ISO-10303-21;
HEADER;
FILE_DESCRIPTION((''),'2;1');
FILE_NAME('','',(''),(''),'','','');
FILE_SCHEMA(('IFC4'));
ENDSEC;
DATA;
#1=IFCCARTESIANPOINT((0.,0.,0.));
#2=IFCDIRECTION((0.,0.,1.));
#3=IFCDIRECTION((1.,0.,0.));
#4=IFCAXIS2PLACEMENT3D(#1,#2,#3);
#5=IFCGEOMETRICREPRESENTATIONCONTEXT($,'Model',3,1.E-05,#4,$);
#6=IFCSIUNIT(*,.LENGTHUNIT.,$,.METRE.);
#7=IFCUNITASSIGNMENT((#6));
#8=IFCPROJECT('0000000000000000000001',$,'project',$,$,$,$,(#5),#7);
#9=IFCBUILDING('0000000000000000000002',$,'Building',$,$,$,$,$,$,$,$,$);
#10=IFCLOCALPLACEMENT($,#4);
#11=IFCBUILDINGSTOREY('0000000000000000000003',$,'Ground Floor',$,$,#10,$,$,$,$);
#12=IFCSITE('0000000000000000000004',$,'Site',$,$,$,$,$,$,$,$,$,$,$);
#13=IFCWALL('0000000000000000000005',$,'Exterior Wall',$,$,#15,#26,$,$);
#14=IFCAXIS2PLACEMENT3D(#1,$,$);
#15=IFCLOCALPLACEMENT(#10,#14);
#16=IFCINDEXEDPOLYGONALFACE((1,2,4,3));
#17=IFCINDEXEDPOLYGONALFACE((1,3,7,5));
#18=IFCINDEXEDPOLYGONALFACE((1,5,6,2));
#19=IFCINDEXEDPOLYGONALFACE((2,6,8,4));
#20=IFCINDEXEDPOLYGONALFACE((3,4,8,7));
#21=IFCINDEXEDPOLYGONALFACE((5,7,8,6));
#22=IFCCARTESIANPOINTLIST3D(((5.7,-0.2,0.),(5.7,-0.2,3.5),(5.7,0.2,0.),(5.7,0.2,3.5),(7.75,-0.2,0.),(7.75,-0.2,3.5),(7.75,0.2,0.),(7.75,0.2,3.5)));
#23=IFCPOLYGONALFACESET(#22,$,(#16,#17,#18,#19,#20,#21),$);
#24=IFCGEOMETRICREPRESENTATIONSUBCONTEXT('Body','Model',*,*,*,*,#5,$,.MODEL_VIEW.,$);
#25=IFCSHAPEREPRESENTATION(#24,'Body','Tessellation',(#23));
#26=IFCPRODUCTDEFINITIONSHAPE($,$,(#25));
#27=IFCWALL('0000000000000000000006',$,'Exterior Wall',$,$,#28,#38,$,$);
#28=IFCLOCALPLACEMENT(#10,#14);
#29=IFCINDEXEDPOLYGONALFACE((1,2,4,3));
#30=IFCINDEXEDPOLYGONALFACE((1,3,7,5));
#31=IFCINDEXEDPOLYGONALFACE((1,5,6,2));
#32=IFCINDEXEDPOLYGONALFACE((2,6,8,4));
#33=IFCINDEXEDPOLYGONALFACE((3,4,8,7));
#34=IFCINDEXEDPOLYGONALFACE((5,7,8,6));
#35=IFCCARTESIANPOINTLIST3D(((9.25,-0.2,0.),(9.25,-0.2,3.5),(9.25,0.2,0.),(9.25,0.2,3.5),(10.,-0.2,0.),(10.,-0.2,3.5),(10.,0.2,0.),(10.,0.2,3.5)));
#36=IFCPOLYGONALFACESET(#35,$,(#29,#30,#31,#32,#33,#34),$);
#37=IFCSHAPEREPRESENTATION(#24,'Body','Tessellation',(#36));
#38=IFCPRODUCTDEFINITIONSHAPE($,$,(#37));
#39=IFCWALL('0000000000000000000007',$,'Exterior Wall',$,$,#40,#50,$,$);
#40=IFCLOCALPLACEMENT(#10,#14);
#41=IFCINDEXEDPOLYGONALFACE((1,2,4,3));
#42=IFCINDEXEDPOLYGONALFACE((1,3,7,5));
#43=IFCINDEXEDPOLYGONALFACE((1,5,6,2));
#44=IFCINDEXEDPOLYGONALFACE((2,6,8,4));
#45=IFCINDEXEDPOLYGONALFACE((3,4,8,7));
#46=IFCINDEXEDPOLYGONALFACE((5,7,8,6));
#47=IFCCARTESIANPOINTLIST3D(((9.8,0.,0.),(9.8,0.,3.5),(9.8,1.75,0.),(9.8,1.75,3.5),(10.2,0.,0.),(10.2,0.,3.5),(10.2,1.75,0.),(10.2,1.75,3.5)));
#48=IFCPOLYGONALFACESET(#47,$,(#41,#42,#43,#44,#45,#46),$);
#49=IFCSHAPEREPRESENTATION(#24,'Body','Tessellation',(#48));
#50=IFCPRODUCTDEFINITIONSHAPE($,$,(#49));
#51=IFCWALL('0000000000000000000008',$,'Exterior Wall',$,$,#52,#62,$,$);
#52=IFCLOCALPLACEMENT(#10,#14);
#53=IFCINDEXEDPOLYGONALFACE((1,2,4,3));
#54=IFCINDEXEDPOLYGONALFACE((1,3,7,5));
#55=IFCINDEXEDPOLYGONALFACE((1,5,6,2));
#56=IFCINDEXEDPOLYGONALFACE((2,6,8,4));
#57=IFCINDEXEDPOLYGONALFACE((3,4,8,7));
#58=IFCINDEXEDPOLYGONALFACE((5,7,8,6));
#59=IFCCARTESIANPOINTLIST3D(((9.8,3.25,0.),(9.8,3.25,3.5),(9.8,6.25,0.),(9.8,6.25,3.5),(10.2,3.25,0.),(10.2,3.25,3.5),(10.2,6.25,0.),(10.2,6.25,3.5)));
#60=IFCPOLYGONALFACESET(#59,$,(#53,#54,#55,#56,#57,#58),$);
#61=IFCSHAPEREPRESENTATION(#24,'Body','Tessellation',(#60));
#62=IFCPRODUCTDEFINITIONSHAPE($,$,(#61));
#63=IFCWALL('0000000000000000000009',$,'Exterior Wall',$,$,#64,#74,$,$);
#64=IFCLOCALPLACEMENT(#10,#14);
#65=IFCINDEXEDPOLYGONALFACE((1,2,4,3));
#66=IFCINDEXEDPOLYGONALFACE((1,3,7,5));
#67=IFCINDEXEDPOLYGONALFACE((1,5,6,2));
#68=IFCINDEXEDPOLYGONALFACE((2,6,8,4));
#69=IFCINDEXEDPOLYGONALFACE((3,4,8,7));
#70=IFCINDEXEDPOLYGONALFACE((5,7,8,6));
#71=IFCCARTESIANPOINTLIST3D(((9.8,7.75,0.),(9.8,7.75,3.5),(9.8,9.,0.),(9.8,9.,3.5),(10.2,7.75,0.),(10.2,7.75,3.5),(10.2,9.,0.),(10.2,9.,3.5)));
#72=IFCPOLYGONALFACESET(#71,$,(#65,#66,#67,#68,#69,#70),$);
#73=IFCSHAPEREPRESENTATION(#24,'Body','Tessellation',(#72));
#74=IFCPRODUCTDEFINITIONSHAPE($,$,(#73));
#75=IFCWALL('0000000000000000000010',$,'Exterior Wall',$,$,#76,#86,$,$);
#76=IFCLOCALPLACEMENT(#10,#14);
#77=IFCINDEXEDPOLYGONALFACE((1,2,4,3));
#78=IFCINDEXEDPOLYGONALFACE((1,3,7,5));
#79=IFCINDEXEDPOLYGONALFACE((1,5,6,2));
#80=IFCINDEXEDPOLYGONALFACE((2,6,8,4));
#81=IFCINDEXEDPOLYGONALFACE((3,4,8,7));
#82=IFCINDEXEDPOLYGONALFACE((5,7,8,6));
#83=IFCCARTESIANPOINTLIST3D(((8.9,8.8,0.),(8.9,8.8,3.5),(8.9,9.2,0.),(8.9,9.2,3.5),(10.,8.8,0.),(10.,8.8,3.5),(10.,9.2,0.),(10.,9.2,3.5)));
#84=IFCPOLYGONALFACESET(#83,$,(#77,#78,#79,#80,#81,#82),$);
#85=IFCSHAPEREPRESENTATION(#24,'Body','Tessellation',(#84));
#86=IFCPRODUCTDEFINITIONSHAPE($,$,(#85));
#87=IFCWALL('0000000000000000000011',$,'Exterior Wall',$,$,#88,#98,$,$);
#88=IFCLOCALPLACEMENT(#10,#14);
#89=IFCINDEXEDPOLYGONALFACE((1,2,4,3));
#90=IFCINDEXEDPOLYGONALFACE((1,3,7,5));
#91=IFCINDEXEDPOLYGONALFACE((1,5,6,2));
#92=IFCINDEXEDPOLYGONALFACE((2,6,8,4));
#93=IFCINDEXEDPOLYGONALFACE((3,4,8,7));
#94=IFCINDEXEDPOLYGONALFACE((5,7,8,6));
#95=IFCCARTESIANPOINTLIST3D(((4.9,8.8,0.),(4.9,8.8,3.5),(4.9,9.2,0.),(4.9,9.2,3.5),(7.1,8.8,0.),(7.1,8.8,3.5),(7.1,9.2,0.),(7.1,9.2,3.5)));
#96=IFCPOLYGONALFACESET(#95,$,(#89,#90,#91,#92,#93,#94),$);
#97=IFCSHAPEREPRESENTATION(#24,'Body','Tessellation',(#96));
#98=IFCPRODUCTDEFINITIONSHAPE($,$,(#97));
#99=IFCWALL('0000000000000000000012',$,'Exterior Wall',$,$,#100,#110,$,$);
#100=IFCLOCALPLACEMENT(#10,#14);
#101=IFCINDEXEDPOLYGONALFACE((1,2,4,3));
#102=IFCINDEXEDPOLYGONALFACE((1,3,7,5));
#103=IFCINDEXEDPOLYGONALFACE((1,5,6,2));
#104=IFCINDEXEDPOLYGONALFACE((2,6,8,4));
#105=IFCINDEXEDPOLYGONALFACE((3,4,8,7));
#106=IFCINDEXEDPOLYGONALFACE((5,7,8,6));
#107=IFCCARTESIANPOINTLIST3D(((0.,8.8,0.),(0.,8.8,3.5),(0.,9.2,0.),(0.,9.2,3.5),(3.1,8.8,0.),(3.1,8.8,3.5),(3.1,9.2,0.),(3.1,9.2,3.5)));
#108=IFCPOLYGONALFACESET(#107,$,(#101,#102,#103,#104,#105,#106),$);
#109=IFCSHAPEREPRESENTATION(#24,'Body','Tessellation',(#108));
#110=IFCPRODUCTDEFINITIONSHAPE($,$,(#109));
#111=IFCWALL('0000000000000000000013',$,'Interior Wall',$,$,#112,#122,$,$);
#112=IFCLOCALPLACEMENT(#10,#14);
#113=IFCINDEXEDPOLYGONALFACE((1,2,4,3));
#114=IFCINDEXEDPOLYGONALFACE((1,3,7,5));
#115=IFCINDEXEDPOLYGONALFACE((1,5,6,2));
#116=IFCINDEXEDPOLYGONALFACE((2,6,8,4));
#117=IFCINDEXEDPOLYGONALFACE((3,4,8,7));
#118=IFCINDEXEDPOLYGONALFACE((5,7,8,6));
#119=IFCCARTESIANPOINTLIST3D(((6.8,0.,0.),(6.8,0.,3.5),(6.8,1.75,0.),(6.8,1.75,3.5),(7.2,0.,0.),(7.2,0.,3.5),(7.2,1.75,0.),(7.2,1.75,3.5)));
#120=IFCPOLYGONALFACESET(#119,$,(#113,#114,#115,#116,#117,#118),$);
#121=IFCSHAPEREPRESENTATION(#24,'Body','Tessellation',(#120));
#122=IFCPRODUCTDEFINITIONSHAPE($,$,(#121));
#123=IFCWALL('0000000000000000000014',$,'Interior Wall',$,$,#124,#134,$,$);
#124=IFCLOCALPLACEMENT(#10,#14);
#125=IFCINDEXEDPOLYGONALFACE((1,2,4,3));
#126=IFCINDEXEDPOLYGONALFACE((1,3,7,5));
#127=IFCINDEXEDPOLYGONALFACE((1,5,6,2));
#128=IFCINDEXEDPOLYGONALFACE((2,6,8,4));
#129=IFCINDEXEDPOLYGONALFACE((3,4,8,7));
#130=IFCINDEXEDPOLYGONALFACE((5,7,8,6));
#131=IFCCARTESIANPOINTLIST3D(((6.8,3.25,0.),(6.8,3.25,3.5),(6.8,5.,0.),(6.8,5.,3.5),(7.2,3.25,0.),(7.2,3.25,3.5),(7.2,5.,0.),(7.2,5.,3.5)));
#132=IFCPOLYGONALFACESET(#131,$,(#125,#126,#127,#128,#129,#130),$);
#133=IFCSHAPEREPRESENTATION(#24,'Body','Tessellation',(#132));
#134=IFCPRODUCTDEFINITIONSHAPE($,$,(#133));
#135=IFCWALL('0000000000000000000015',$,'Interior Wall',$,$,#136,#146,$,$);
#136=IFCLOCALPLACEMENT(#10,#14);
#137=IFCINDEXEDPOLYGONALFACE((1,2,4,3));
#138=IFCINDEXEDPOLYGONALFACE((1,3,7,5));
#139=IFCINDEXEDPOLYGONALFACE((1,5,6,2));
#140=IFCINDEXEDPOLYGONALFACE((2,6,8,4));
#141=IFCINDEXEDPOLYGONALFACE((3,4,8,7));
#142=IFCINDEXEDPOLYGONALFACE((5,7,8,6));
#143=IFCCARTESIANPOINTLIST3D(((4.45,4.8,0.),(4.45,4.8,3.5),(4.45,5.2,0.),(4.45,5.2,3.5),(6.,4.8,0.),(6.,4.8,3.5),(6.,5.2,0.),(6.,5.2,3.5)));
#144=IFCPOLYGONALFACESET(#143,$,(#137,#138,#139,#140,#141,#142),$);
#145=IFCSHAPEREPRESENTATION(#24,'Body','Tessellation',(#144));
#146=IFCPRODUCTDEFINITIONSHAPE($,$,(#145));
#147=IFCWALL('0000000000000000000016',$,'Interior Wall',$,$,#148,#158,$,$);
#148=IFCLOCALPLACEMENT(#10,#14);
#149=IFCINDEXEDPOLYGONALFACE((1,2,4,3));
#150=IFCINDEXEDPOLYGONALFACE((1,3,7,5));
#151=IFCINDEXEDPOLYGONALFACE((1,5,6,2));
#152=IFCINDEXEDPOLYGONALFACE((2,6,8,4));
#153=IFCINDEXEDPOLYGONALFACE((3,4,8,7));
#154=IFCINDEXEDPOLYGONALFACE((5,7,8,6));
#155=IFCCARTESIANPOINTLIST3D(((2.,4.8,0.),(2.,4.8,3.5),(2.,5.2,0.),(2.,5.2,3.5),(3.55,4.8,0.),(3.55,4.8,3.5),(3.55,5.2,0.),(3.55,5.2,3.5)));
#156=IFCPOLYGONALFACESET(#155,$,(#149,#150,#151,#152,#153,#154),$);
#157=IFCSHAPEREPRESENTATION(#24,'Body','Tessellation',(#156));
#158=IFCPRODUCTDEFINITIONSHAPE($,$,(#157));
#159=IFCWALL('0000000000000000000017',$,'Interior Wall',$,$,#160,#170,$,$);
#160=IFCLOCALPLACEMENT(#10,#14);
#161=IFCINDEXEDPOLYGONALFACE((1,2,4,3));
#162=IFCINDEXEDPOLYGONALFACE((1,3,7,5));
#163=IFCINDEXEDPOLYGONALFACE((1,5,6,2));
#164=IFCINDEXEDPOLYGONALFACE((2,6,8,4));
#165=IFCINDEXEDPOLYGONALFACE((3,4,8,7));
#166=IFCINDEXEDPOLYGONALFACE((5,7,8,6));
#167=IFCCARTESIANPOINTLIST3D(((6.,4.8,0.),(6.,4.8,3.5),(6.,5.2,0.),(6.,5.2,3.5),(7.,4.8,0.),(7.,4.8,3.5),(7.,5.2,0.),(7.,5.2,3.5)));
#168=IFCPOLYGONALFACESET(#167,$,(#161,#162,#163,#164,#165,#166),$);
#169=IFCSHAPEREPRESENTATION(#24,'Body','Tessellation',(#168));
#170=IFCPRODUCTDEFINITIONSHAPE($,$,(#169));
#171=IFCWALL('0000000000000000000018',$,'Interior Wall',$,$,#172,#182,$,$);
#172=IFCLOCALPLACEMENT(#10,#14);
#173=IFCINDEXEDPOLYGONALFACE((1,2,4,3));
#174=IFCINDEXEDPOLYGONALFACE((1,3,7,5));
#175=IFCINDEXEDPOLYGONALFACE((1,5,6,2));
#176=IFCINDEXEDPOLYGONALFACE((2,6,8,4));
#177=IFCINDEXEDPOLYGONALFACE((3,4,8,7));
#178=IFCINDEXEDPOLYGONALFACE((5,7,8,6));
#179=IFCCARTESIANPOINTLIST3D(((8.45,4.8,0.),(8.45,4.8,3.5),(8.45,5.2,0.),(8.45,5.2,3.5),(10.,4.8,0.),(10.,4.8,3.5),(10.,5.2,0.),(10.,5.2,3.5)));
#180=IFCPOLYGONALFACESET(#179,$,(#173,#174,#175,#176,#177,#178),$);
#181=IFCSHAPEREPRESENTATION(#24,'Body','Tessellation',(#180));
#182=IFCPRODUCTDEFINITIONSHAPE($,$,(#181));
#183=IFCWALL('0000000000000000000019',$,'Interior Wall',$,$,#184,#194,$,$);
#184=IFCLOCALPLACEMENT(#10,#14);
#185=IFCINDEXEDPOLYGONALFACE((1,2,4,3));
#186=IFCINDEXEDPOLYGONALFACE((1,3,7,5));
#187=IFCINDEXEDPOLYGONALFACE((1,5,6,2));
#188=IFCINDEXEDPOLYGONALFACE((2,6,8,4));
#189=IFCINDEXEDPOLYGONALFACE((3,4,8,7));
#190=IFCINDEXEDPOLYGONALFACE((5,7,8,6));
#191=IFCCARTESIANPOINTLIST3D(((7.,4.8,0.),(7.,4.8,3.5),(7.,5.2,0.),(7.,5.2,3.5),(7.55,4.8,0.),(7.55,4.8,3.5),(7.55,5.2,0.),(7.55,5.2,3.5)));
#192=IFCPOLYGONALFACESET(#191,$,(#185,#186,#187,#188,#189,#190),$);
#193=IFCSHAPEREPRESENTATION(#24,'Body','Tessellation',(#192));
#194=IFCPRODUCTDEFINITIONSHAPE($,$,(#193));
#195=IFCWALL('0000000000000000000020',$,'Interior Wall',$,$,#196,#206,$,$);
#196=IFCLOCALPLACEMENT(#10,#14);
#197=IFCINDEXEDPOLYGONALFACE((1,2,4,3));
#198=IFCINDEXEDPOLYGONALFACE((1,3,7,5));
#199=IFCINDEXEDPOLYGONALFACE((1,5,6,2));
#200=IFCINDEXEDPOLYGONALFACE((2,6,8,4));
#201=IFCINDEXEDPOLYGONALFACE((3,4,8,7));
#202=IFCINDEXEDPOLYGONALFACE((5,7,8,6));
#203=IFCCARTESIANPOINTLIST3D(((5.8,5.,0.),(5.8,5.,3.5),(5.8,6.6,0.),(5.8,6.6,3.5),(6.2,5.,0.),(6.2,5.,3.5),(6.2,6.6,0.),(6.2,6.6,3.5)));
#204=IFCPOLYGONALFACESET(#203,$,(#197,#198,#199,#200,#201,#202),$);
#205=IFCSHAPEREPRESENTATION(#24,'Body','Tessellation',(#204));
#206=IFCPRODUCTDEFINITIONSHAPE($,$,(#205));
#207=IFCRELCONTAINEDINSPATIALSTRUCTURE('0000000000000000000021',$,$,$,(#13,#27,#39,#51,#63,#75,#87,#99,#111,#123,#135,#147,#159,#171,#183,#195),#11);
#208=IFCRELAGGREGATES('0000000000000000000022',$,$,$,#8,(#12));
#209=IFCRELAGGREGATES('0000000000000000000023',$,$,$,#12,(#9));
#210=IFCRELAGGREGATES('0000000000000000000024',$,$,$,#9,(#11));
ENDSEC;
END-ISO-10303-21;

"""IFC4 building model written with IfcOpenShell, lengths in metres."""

from ifc_helpers import new_model, si_unit, frame, origin_with_axes, place, context, subcontext, project, spatial, indexed_curve, outline, extrude, element, save


model = new_model("IFC4")

# Units and contexts
model_context = context("Model", 3, precision=1e-05, world=origin_with_axes())
body_context = subcontext(model_context, "Body", "Model", "MODEL_VIEW")
ifc_project = project(units=[si_unit("LENGTHUNIT", "METRE")], contexts=[model_context])

# Site, building, storey
site = spatial("IfcSite", under=ifc_project, Name="Site")
building = spatial("IfcBuilding", under=site, Name="Building")
storey_placement = place(None, origin_with_axes())
storey = spatial("IfcBuildingStorey", under=building, at=storey_placement, Name="Ground Floor")

# Walls
wall_1_placement = place(storey_placement, frame((5.7, 0.0, 0.0), z_axis=(0.0, 0.0, 1.0), x_axis=(1.0, 0.0, 0.0)))
element("IfcWall", 1, at=wall_1_placement, inside=storey, Name="Exterior Wall", context=body_context, shape_type="SweptSolid", body=[
    extrude(outline(indexed_curve([(0.0, 0.0), (0.0, 0.4), (2.05, 0.4), (2.05, 0.0), (0.0, 0.0)], self_intersect=False)), frame((0.0, -0.2, 0.0), z_axis=(0.0, 0.0, 1.0), x_axis=(1.0, 0.0, 0.0)), (0.0, 0.0, 1.0), 3.5),
])
wall_2_placement = place(storey_placement, frame((9.25, 0.0, 0.0), z_axis=(0.0, 0.0, 1.0), x_axis=(1.0, 0.0, 0.0)))
element("IfcWall", 2, at=wall_2_placement, inside=storey, Name="Exterior Wall", context=body_context, shape_type="SweptSolid", body=[
    extrude(outline(indexed_curve([(0.0, 0.0), (0.0, 0.4), (0.75, 0.4), (0.75, 0.0), (0.0, 0.0)], self_intersect=False)), frame((0.0, -0.2, 0.0), z_axis=(0.0, 0.0, 1.0), x_axis=(1.0, 0.0, 0.0)), (0.0, 0.0, 1.0), 3.5),
])
wall_3_placement = place(storey_placement, frame((10.0, 0.0, 0.0), z_axis=(0.0, 0.0, 1.0), x_axis=(0.0, 1.0, 0.0)))
element("IfcWall", 3, at=wall_3_placement, inside=storey, Name="Exterior Wall", context=body_context, shape_type="SweptSolid", body=[
    extrude(outline(indexed_curve([(0.0, 0.0), (0.0, 0.4), (1.75, 0.4), (1.75, 0.0), (0.0, 0.0)], self_intersect=False)), frame((0.0, -0.2, 0.0), z_axis=(0.0, 0.0, 1.0), x_axis=(1.0, 0.0, 0.0)), (0.0, 0.0, 1.0), 3.5),
])
wall_4_placement = place(storey_placement, frame((10.0, 3.25, 0.0), z_axis=(0.0, 0.0, 1.0), x_axis=(0.0, 1.0, 0.0)))
element("IfcWall", 4, at=wall_4_placement, inside=storey, Name="Exterior Wall", context=body_context, shape_type="SweptSolid", body=[
    extrude(outline(indexed_curve([(0.0, 0.0), (0.0, 0.4), (3.0, 0.4), (3.0, 0.0), (0.0, 0.0)], self_intersect=False)), frame((0.0, -0.2, 0.0), z_axis=(0.0, 0.0, 1.0), x_axis=(1.0, 0.0, 0.0)), (0.0, 0.0, 1.0), 3.5),
])
wall_5_placement = place(storey_placement, frame((10.0, 7.75, 0.0), z_axis=(0.0, 0.0, 1.0), x_axis=(0.0, 1.0, 0.0)))
element("IfcWall", 5, at=wall_5_placement, inside=storey, Name="Exterior Wall", context=body_context, shape_type="SweptSolid", body=[
    extrude(outline(indexed_curve([(0.0, 0.0), (0.0, 0.4), (1.25, 0.4), (1.25, 0.0), (0.0, 0.0)], self_intersect=False)), frame((0.0, -0.2, 0.0), z_axis=(0.0, 0.0, 1.0), x_axis=(1.0, 0.0, 0.0)), (0.0, 0.0, 1.0), 3.5),
])
wall_6_placement = place(storey_placement, frame((10.0, 9.0, 0.0), z_axis=(0.0, 0.0, 1.0), x_axis=(-1.0, 0.0, 0.0)))
element("IfcWall", 6, at=wall_6_placement, inside=storey, Name="Exterior Wall", context=body_context, shape_type="SweptSolid", body=[
    extrude(outline(indexed_curve([(0.0, 0.0), (0.0, 0.4), (1.1, 0.4), (1.1, 0.0), (0.0, 0.0)], self_intersect=False)), frame((0.0, -0.2, 0.0), z_axis=(0.0, 0.0, 1.0), x_axis=(1.0, 0.0, 0.0)), (0.0, 0.0, 1.0), 3.5),
])
wall_7_placement = place(storey_placement, frame((7.1, 9.0, 0.0), z_axis=(0.0, 0.0, 1.0), x_axis=(-1.0, 0.0, 0.0)))
element("IfcWall", 7, at=wall_7_placement, inside=storey, Name="Exterior Wall", context=body_context, shape_type="SweptSolid", body=[
    extrude(outline(indexed_curve([(0.0, 0.0), (0.0, 0.4), (2.2, 0.4), (2.2, 0.0), (0.0, 0.0)], self_intersect=False)), frame((0.0, -0.2, 0.0), z_axis=(0.0, 0.0, 1.0), x_axis=(1.0, 0.0, 0.0)), (0.0, 0.0, 1.0), 3.5),
])
wall_8_placement = place(storey_placement, frame((3.1, 9.0, 0.0), z_axis=(0.0, 0.0, 1.0), x_axis=(-1.0, 0.0, 0.0)))
element("IfcWall", 8, at=wall_8_placement, inside=storey, Name="Exterior Wall", context=body_context, shape_type="SweptSolid", body=[
    extrude(outline(indexed_curve([(0.0, 0.0), (0.0, 0.4), (3.1, 0.4), (3.1, 0.0), (0.0, 0.0)], self_intersect=False)), frame((0.0, -0.2, 0.0), z_axis=(0.0, 0.0, 1.0), x_axis=(1.0, 0.0, 0.0)), (0.0, 0.0, 1.0), 3.5),
])
for number, where, z_axis, x_axis, name in (
    (9, (7.0, 0.0, 0.0), (0.0, 0.0, 1.0), (0.0, 1.0, 0.0), "Interior Wall"),
    (10, (7.0, 3.25, 0.0), (0.0, 0.0, 1.0), (0.0, 1.0, 0.0), "Interior Wall"),
):
    element("IfcWall", number, at=place(storey_placement, frame(where, z_axis=z_axis, x_axis=x_axis)), inside=storey, Name=name, context=body_context, shape_type="SweptSolid", body=[
        extrude(outline(indexed_curve([(0.0, 0.0), (0.0, 0.4), (1.75, 0.4), (1.75, 0.0), (0.0, 0.0)], self_intersect=False)), frame((0.0, -0.2, 0.0), z_axis=(0.0, 0.0, 1.0), x_axis=(1.0, 0.0, 0.0)), (0.0, 0.0, 1.0), 3.5),
    ])
for number, where, z_axis, x_axis, name in (
    (11, (6.0, 5.0, 0.0), (0.0, 0.0, 1.0), (-1.0, 0.0, 0.0), "Interior Wall"),
    (12, (3.55, 5.0, 0.0), (0.0, 0.0, 1.0), (-1.0, 0.0, 0.0), "Interior Wall"),
):
    element("IfcWall", number, at=place(storey_placement, frame(where, z_axis=z_axis, x_axis=x_axis)), inside=storey, Name=name, context=body_context, shape_type="SweptSolid", body=[
        extrude(outline(indexed_curve([(0.0, 0.0), (0.0, 0.4), (1.55, 0.4), (1.55, 0.0), (0.0, 0.0)], self_intersect=False)), frame((0.0, -0.2, 0.0), z_axis=(0.0, 0.0, 1.0), x_axis=(1.0, 0.0, 0.0)), (0.0, 0.0, 1.0), 3.5),
    ])
wall_9_placement = place(storey_placement, frame((7.0, 5.0, 0.0), z_axis=(0.0, 0.0, 1.0), x_axis=(-1.0, 0.0, 0.0)))
element("IfcWall", 13, at=wall_9_placement, inside=storey, Name="Interior Wall", context=body_context, shape_type="SweptSolid", body=[
    extrude(outline(indexed_curve([(0.0, 0.0), (0.0, 0.4), (1.0, 0.4), (1.0, 0.0), (0.0, 0.0)], self_intersect=False)), frame((0.0, -0.2, 0.0), z_axis=(0.0, 0.0, 1.0), x_axis=(1.0, 0.0, 0.0)), (0.0, 0.0, 1.0), 3.5),
])
wall_10_placement = place(storey_placement, frame((10.0, 5.0, 0.0), z_axis=(0.0, 0.0, 1.0), x_axis=(-1.0, 0.0, 0.0)))
element("IfcWall", 14, at=wall_10_placement, inside=storey, Name="Interior Wall", context=body_context, shape_type="SweptSolid", body=[
    extrude(outline(indexed_curve([(0.0, 0.0), (0.0, 0.4), (1.55, 0.4), (1.55, 0.0), (0.0, 0.0)], self_intersect=False)), frame((0.0, -0.2, 0.0), z_axis=(0.0, 0.0, 1.0), x_axis=(1.0, 0.0, 0.0)), (0.0, 0.0, 1.0), 3.5),
])
wall_11_placement = place(storey_placement, frame((7.55, 5.0, 0.0), z_axis=(0.0, 0.0, 1.0), x_axis=(-1.0, 0.0, 0.0)))
element("IfcWall", 15, at=wall_11_placement, inside=storey, Name="Interior Wall", context=body_context, shape_type="SweptSolid", body=[
    extrude(outline(indexed_curve([(0.0, 0.0), (0.0, 0.4), (0.55, 0.4), (0.55, 0.0), (0.0, 0.0)], self_intersect=False)), frame((0.0, -0.2, 0.0), z_axis=(0.0, 0.0, 1.0), x_axis=(1.0, 0.0, 0.0)), (0.0, 0.0, 1.0), 3.5),
])
for number, where, z_axis, x_axis, name in (
    (16, (6.0, 5.0, 0.0), (0.0, 0.0, 1.0), (0.0, 1.0, 0.0), "Interior Wall"),
):
    element("IfcWall", number, at=place(storey_placement, frame(where, z_axis=z_axis, x_axis=x_axis)), inside=storey, Name=name, context=body_context, shape_type="SweptSolid", body=[
        extrude(outline(indexed_curve([(0.0, 0.0), (0.0, 0.4), (1.6, 0.4), (1.6, 0.0), (0.0, 0.0)], self_intersect=False)), frame((0.0, -0.2, 0.0), z_axis=(0.0, 0.0, 1.0), x_axis=(1.0, 0.0, 0.0)), (0.0, 0.0, 1.0), 3.5),
    ])

save(model, "model.ifc")
